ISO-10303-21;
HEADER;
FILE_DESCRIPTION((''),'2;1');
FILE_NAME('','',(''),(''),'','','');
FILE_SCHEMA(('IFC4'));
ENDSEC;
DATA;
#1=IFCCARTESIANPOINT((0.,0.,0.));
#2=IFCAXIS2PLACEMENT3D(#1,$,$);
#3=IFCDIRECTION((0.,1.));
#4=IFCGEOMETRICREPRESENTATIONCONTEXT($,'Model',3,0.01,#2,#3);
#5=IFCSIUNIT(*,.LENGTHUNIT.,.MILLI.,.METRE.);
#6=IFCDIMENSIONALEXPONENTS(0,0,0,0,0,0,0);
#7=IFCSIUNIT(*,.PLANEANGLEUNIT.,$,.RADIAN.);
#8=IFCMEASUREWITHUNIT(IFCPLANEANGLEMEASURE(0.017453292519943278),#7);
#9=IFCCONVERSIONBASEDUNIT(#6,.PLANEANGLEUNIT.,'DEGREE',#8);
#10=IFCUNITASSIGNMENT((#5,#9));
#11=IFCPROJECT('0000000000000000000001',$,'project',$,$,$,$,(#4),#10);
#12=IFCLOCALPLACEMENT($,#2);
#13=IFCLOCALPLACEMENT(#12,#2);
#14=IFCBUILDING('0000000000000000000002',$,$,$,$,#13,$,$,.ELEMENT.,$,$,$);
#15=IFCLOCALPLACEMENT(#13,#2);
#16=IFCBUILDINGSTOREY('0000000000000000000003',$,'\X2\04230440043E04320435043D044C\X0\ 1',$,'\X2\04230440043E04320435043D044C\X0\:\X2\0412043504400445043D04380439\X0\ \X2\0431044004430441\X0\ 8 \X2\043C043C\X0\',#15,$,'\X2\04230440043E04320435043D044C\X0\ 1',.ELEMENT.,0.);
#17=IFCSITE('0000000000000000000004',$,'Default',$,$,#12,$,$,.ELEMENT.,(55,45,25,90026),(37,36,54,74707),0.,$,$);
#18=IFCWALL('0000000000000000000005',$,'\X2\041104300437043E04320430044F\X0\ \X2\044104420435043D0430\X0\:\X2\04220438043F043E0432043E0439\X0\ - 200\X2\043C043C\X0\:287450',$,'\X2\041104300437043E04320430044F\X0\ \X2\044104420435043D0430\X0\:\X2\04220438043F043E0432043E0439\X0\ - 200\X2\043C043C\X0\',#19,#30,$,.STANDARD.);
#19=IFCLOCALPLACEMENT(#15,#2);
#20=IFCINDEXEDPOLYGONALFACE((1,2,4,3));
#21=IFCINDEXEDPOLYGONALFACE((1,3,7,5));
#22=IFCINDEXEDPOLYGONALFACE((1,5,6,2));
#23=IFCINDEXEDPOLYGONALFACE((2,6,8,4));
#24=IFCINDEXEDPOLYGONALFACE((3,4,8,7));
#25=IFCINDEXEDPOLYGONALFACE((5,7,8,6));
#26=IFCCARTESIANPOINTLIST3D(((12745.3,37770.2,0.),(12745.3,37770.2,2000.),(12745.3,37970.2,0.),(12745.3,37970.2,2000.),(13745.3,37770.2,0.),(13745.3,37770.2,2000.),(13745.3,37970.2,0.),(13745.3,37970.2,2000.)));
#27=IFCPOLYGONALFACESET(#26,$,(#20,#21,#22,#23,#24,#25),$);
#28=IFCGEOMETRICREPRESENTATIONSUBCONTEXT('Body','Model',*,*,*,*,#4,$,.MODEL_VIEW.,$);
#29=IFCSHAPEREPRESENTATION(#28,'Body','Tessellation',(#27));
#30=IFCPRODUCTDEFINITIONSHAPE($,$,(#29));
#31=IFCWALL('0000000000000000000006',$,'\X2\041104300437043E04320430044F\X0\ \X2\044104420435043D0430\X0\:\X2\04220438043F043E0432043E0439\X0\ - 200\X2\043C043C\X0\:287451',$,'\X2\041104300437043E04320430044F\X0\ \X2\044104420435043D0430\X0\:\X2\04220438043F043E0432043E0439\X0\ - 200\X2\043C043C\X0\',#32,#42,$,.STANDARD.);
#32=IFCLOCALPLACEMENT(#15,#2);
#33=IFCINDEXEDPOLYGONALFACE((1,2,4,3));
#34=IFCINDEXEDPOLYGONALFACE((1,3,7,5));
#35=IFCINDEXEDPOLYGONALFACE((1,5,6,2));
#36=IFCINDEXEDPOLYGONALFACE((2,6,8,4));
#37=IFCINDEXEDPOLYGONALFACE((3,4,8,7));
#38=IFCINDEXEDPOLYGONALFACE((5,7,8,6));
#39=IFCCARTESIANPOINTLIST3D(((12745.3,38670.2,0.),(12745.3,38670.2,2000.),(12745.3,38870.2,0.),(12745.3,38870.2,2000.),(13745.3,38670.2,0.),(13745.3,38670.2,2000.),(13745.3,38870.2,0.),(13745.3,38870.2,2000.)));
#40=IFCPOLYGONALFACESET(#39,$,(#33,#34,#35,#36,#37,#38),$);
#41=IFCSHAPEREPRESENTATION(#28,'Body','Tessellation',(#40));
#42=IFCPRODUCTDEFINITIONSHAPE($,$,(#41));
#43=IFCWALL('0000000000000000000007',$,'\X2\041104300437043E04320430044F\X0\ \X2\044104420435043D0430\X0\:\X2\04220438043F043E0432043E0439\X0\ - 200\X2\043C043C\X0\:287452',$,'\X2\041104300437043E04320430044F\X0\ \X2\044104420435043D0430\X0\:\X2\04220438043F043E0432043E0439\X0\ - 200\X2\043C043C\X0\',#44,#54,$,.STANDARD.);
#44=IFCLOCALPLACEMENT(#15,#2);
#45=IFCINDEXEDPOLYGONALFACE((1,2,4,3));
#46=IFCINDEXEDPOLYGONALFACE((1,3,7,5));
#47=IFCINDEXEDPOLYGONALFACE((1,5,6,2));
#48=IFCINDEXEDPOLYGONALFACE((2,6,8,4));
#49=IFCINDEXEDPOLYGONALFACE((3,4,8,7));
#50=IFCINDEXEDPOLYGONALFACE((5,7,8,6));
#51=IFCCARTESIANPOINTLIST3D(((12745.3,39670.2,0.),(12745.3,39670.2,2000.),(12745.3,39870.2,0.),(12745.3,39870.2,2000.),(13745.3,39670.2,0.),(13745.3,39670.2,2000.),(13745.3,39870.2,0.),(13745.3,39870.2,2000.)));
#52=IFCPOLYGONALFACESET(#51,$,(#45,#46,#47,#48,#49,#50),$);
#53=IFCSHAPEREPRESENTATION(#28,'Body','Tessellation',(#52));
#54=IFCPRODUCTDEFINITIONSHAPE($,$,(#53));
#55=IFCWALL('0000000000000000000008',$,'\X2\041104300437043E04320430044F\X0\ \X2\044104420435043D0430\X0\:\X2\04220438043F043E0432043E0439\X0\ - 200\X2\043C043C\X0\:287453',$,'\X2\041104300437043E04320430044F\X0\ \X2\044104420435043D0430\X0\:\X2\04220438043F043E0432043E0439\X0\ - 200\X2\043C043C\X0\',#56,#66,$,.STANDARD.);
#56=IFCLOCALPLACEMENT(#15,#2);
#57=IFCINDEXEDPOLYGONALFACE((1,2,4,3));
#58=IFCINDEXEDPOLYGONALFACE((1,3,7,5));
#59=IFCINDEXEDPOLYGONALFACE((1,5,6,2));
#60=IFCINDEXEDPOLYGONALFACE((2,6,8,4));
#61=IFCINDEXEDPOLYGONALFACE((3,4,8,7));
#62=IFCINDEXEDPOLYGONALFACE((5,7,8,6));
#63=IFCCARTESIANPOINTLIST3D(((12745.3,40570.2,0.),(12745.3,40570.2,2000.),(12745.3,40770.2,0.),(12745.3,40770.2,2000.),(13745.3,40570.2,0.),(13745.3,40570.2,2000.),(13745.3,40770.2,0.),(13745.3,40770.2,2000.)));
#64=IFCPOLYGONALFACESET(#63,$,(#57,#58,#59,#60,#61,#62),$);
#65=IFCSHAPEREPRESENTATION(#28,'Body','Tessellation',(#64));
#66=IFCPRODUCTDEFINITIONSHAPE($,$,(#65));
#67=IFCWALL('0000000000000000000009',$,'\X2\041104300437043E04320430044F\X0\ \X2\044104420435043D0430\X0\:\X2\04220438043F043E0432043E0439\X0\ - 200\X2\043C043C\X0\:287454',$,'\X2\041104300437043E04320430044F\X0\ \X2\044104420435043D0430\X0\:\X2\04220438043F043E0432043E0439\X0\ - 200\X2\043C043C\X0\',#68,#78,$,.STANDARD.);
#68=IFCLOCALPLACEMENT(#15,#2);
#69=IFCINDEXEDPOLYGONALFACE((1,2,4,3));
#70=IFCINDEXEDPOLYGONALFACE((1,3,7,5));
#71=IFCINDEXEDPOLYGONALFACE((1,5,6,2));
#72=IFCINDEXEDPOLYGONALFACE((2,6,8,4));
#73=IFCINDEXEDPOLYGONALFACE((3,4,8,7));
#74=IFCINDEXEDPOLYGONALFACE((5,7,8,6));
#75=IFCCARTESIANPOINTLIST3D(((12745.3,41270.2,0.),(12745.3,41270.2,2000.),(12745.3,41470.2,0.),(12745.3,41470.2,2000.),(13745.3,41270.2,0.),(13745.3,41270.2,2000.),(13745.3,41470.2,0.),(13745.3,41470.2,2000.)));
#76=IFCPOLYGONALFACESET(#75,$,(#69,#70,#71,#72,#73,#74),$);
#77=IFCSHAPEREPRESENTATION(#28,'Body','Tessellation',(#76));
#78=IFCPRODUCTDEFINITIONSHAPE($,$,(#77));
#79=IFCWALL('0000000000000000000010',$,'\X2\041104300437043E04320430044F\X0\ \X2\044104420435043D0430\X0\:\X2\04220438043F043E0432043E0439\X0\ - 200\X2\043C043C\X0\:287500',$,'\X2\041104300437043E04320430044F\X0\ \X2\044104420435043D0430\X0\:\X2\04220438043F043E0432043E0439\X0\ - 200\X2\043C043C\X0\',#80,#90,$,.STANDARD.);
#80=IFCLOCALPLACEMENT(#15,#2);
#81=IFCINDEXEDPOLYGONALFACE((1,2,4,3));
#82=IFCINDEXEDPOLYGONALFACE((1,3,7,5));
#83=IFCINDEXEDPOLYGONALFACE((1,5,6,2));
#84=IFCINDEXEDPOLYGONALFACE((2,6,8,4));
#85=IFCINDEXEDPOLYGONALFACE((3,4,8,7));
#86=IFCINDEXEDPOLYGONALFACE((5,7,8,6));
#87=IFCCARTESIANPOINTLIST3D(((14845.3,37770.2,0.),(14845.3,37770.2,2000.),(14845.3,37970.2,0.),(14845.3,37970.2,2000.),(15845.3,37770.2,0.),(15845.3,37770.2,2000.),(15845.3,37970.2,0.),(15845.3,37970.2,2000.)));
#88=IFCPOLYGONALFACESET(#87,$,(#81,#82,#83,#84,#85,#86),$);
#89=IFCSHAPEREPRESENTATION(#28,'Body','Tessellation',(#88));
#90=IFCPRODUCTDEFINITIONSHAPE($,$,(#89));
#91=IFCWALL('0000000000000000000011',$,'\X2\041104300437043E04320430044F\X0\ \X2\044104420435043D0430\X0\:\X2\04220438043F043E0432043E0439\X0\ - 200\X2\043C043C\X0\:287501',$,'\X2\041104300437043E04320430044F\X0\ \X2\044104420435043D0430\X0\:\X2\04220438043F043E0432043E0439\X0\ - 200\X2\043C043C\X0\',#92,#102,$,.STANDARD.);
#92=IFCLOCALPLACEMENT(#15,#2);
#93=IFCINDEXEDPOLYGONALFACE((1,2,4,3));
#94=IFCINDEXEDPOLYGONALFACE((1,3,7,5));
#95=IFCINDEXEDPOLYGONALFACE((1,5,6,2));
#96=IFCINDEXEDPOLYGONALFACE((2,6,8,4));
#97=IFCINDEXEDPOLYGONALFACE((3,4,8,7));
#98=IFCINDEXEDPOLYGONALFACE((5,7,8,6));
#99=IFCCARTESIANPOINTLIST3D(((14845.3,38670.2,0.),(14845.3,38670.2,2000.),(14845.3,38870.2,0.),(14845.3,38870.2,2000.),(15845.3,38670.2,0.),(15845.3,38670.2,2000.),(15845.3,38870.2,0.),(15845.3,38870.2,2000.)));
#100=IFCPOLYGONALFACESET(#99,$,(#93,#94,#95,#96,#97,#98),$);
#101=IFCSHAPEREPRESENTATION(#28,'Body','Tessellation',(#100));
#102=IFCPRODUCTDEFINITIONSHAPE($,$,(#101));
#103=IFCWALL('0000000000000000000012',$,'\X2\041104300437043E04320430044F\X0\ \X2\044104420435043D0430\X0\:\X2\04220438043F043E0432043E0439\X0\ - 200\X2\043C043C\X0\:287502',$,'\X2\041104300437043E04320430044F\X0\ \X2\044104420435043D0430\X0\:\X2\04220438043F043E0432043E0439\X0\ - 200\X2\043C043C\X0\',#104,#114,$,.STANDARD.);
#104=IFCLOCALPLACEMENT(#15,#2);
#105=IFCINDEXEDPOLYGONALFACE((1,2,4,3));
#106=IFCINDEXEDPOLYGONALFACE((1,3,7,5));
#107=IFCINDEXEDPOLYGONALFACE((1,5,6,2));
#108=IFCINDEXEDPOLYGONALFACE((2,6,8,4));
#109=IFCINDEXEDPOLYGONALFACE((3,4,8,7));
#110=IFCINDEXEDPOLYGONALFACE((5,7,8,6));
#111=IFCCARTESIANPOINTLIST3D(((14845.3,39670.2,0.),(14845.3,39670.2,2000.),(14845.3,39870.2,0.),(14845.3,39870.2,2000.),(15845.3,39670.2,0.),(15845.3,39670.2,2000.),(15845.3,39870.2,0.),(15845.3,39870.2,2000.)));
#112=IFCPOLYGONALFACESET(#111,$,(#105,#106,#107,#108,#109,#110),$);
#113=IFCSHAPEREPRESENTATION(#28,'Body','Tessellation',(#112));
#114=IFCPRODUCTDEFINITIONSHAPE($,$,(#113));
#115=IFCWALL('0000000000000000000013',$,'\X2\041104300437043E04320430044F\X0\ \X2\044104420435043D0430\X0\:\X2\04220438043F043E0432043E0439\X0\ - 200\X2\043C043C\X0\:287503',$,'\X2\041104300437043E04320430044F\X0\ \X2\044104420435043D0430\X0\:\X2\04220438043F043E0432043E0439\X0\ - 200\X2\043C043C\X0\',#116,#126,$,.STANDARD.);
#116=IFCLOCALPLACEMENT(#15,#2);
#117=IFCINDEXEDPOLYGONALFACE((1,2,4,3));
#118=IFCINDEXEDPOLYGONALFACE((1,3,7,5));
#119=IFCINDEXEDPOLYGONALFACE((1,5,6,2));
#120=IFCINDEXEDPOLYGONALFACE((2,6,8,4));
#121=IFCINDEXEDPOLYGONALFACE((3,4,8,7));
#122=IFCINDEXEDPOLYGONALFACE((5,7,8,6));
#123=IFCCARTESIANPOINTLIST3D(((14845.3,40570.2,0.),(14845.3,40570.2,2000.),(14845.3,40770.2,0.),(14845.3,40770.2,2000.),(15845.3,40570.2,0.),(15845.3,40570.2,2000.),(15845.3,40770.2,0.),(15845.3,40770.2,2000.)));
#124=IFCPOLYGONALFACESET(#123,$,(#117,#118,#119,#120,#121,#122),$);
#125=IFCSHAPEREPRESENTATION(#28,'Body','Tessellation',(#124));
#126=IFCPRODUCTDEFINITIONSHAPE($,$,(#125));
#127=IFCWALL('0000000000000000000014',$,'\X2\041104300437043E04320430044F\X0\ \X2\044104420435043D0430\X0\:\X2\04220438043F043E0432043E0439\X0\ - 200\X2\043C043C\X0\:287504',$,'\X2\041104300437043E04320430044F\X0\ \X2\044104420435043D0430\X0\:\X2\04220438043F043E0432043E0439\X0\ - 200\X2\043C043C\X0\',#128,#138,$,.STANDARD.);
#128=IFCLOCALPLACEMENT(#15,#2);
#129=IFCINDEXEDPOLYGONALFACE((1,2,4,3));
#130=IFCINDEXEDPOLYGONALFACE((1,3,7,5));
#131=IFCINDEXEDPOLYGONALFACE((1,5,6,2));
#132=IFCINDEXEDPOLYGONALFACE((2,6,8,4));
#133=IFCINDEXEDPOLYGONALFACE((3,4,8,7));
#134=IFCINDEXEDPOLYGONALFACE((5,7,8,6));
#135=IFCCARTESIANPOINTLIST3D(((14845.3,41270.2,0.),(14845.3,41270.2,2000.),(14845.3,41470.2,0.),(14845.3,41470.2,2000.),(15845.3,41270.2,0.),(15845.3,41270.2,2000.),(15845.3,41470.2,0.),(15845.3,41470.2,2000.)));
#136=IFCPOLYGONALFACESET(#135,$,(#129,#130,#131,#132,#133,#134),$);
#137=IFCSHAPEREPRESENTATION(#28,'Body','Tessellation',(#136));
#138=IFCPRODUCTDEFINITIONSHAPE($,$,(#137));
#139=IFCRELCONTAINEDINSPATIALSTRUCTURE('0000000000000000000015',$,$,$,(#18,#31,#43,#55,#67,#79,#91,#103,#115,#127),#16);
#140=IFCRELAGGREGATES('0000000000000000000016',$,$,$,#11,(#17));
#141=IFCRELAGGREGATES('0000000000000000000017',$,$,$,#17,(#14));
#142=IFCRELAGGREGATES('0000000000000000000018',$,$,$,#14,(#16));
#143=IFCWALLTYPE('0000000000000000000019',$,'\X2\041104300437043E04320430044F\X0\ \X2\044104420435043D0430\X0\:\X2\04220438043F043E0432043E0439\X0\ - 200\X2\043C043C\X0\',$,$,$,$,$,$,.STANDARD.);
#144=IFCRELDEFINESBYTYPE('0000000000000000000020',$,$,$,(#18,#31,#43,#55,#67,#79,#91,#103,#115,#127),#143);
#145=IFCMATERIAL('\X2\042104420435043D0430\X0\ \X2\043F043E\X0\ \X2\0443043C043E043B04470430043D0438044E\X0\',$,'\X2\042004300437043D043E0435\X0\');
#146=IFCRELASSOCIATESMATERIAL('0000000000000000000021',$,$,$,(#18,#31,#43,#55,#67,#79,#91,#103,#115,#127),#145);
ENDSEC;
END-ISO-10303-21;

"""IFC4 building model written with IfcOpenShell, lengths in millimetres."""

from ifc_helpers import new_model, entity, si_unit, converted_unit, direction, frame, origin, place, context, subcontext, project, spatial, indexed_curve, outline, extrude, material, type_object, element, save


model = new_model("IFC4")

# Units and contexts
model_context = context("Model", 3, precision=0.01, world=origin(), true_north=direction((0.0, 1.0)))
body_context = subcontext(model_context, "Body", "Model", "MODEL_VIEW")
ifc_project = project(units=[si_unit("LENGTHUNIT", "METRE", prefix="MILLI"), converted_unit("PLANEANGLEUNIT", "DEGREE", entity("IfcPlaneAngleMeasure", 0.017453292519943278), si_unit("PLANEANGLEUNIT", "RADIAN"), dimensions=[0, 0, 0, 0, 0, 0, 0])], contexts=[model_context])

# Site, building, storey
site_placement = place(None, origin())
site = spatial("IfcSite", under=ifc_project, at=site_placement, Name="Default", CompositionType="ELEMENT", RefLatitude=(55, 45, 25, 90026), RefLongitude=(37, 36, 54, 74707), RefElevation=0.0)
building_placement = place(site_placement, origin())
building = spatial("IfcBuilding", under=site, at=building_placement, CompositionType="ELEMENT")
storey_placement = place(building_placement, origin())
storey = spatial("IfcBuildingStorey", under=building, at=storey_placement, Name="Уровень 1", ObjectType="Уровень:Верхний брус 8 мм", LongName="Уровень 1", CompositionType="ELEMENT", Elevation=0.0)

# Walls
ifc_material = material(Name="Стена по умолчанию", Category="Разное")
wall_type = type_object("IfcWallType", Name="Базовая стена:Типовой - 200мм", PredefinedType="STANDARD")
for number, where, name in (
    (1, (12745.3, 37870.2, 0.0), "Базовая стена:Типовой - 200мм:287450"),
    (2, (12745.3, 38770.2, 0.0), "Базовая стена:Типовой - 200мм:287451"),
):
    element("IfcWall", number, at=place(storey_placement, frame(where)), inside=storey, type_object=wall_type, material=ifc_material, Name=name, ObjectType="Базовая стена:Типовой - 200мм", PredefinedType="STANDARD", context=body_context, shape_type="SweptSolid", body=[
        extrude(outline(indexed_curve([(1000.0, 100.0), (0.0, 100.0), (0.0, -100.0), (1000.0, -100.0), (1000.0, 100.0)], self_intersect=False)), origin(), (0.0, 0.0, 1.0), 2000.0),
    ])
wall_1_placement = place(storey_placement, frame((12745.3, 39770.2, 0.0)))
element("IfcWall", 3, at=wall_1_placement, inside=storey, type_object=wall_type, material=ifc_material, Name="Базовая стена:Типовой - 200мм:287452", ObjectType="Базовая стена:Типовой - 200мм", PredefinedType="STANDARD", context=body_context, shape_type="SweptSolid", body=[
    extrude(outline(indexed_curve([(1000.0, 100.0), (0.0, 100.0), (0.0, -100.0), (1000.0, -100.0), (1000.0, 100.0)], self_intersect=False)), origin(), (0.0, 0.0, 1.0), 2000.0),
])
for number, where, name in (
    (4, (12745.3, 40670.2, 0.0), "Базовая стена:Типовой - 200мм:287453"),
    (5, (12745.3, 41370.2, 0.0), "Базовая стена:Типовой - 200мм:287454"),
):
    element("IfcWall", number, at=place(storey_placement, frame(where)), inside=storey, type_object=wall_type, material=ifc_material, Name=name, ObjectType="Базовая стена:Типовой - 200мм", PredefinedType="STANDARD", context=body_context, shape_type="SweptSolid", body=[
        extrude(outline(indexed_curve([(1000.0, 100.0), (0.0, 100.0), (0.0, -100.0), (1000.0, -100.0), (1000.0, 100.0)], self_intersect=False)), origin(), (0.0, 0.0, 1.0), 2000.0),
    ])
wall_2_placement = place(storey_placement, frame((14845.3, 37870.2, 0.0)))
element("IfcWall", 6, at=wall_2_placement, inside=storey, type_object=wall_type, material=ifc_material, Name="Базовая стена:Типовой - 200мм:287500", ObjectType="Базовая стена:Типовой - 200мм", PredefinedType="STANDARD", context=body_context, shape_type="SweptSolid", body=[
    extrude(outline(indexed_curve([(1000.0, 100.0), (0.0, 100.0), (0.0, -100.0), (1000.0, -100.0), (1000.0, 100.0)], self_intersect=False)), origin(), (0.0, 0.0, 1.0), 2000.0),
])
wall_3_placement = place(storey_placement, frame((14845.3, 38770.2, 0.0)))
element("IfcWall", 7, at=wall_3_placement, inside=storey, type_object=wall_type, material=ifc_material, Name="Базовая стена:Типовой - 200мм:287501", ObjectType="Базовая стена:Типовой - 200мм", PredefinedType="STANDARD", context=body_context, shape_type="SweptSolid", body=[
    extrude(outline(indexed_curve([(1000.0, 100.0), (0.0, 100.0), (0.0, -100.0), (1000.0, -100.0), (1000.0, 100.0)], self_intersect=False)), origin(), (0.0, 0.0, 1.0), 2000.0),
])
wall_4_placement = place(storey_placement, frame((14845.3, 39770.2, 0.0)))
element("IfcWall", 8, at=wall_4_placement, inside=storey, type_object=wall_type, material=ifc_material, Name="Базовая стена:Типовой - 200мм:287502", ObjectType="Базовая стена:Типовой - 200мм", PredefinedType="STANDARD", context=body_context, shape_type="SweptSolid", body=[
    extrude(outline(indexed_curve([(1000.0, 100.0), (0.0, 100.0), (0.0, -100.0), (1000.0, -100.0), (1000.0, 100.0)], self_intersect=False)), origin(), (0.0, 0.0, 1.0), 2000.0),
])
wall_5_placement = place(storey_placement, frame((14845.3, 40670.2, 0.0)))
element("IfcWall", 9, at=wall_5_placement, inside=storey, type_object=wall_type, material=ifc_material, Name="Базовая стена:Типовой - 200мм:287503", ObjectType="Базовая стена:Типовой - 200мм", PredefinedType="STANDARD", context=body_context, shape_type="SweptSolid", body=[
    extrude(outline(indexed_curve([(1000.0, 100.0), (0.0, 100.0), (0.0, -100.0), (1000.0, -100.0), (1000.0, 100.0)], self_intersect=False)), origin(), (0.0, 0.0, 1.0), 2000.0),
])
wall_6_placement = place(storey_placement, frame((14845.3, 41370.2, 0.0)))
element("IfcWall", 10, at=wall_6_placement, inside=storey, type_object=wall_type, material=ifc_material, Name="Базовая стена:Типовой - 200мм:287504", ObjectType="Базовая стена:Типовой - 200мм", PredefinedType="STANDARD", context=body_context, shape_type="SweptSolid", body=[
    extrude(outline(indexed_curve([(1000.0, 100.0), (0.0, 100.0), (0.0, -100.0), (1000.0, -100.0), (1000.0, 100.0)], self_intersect=False)), origin(), (0.0, 0.0, 1.0), 2000.0),
])

save(model, "model.ifc")
